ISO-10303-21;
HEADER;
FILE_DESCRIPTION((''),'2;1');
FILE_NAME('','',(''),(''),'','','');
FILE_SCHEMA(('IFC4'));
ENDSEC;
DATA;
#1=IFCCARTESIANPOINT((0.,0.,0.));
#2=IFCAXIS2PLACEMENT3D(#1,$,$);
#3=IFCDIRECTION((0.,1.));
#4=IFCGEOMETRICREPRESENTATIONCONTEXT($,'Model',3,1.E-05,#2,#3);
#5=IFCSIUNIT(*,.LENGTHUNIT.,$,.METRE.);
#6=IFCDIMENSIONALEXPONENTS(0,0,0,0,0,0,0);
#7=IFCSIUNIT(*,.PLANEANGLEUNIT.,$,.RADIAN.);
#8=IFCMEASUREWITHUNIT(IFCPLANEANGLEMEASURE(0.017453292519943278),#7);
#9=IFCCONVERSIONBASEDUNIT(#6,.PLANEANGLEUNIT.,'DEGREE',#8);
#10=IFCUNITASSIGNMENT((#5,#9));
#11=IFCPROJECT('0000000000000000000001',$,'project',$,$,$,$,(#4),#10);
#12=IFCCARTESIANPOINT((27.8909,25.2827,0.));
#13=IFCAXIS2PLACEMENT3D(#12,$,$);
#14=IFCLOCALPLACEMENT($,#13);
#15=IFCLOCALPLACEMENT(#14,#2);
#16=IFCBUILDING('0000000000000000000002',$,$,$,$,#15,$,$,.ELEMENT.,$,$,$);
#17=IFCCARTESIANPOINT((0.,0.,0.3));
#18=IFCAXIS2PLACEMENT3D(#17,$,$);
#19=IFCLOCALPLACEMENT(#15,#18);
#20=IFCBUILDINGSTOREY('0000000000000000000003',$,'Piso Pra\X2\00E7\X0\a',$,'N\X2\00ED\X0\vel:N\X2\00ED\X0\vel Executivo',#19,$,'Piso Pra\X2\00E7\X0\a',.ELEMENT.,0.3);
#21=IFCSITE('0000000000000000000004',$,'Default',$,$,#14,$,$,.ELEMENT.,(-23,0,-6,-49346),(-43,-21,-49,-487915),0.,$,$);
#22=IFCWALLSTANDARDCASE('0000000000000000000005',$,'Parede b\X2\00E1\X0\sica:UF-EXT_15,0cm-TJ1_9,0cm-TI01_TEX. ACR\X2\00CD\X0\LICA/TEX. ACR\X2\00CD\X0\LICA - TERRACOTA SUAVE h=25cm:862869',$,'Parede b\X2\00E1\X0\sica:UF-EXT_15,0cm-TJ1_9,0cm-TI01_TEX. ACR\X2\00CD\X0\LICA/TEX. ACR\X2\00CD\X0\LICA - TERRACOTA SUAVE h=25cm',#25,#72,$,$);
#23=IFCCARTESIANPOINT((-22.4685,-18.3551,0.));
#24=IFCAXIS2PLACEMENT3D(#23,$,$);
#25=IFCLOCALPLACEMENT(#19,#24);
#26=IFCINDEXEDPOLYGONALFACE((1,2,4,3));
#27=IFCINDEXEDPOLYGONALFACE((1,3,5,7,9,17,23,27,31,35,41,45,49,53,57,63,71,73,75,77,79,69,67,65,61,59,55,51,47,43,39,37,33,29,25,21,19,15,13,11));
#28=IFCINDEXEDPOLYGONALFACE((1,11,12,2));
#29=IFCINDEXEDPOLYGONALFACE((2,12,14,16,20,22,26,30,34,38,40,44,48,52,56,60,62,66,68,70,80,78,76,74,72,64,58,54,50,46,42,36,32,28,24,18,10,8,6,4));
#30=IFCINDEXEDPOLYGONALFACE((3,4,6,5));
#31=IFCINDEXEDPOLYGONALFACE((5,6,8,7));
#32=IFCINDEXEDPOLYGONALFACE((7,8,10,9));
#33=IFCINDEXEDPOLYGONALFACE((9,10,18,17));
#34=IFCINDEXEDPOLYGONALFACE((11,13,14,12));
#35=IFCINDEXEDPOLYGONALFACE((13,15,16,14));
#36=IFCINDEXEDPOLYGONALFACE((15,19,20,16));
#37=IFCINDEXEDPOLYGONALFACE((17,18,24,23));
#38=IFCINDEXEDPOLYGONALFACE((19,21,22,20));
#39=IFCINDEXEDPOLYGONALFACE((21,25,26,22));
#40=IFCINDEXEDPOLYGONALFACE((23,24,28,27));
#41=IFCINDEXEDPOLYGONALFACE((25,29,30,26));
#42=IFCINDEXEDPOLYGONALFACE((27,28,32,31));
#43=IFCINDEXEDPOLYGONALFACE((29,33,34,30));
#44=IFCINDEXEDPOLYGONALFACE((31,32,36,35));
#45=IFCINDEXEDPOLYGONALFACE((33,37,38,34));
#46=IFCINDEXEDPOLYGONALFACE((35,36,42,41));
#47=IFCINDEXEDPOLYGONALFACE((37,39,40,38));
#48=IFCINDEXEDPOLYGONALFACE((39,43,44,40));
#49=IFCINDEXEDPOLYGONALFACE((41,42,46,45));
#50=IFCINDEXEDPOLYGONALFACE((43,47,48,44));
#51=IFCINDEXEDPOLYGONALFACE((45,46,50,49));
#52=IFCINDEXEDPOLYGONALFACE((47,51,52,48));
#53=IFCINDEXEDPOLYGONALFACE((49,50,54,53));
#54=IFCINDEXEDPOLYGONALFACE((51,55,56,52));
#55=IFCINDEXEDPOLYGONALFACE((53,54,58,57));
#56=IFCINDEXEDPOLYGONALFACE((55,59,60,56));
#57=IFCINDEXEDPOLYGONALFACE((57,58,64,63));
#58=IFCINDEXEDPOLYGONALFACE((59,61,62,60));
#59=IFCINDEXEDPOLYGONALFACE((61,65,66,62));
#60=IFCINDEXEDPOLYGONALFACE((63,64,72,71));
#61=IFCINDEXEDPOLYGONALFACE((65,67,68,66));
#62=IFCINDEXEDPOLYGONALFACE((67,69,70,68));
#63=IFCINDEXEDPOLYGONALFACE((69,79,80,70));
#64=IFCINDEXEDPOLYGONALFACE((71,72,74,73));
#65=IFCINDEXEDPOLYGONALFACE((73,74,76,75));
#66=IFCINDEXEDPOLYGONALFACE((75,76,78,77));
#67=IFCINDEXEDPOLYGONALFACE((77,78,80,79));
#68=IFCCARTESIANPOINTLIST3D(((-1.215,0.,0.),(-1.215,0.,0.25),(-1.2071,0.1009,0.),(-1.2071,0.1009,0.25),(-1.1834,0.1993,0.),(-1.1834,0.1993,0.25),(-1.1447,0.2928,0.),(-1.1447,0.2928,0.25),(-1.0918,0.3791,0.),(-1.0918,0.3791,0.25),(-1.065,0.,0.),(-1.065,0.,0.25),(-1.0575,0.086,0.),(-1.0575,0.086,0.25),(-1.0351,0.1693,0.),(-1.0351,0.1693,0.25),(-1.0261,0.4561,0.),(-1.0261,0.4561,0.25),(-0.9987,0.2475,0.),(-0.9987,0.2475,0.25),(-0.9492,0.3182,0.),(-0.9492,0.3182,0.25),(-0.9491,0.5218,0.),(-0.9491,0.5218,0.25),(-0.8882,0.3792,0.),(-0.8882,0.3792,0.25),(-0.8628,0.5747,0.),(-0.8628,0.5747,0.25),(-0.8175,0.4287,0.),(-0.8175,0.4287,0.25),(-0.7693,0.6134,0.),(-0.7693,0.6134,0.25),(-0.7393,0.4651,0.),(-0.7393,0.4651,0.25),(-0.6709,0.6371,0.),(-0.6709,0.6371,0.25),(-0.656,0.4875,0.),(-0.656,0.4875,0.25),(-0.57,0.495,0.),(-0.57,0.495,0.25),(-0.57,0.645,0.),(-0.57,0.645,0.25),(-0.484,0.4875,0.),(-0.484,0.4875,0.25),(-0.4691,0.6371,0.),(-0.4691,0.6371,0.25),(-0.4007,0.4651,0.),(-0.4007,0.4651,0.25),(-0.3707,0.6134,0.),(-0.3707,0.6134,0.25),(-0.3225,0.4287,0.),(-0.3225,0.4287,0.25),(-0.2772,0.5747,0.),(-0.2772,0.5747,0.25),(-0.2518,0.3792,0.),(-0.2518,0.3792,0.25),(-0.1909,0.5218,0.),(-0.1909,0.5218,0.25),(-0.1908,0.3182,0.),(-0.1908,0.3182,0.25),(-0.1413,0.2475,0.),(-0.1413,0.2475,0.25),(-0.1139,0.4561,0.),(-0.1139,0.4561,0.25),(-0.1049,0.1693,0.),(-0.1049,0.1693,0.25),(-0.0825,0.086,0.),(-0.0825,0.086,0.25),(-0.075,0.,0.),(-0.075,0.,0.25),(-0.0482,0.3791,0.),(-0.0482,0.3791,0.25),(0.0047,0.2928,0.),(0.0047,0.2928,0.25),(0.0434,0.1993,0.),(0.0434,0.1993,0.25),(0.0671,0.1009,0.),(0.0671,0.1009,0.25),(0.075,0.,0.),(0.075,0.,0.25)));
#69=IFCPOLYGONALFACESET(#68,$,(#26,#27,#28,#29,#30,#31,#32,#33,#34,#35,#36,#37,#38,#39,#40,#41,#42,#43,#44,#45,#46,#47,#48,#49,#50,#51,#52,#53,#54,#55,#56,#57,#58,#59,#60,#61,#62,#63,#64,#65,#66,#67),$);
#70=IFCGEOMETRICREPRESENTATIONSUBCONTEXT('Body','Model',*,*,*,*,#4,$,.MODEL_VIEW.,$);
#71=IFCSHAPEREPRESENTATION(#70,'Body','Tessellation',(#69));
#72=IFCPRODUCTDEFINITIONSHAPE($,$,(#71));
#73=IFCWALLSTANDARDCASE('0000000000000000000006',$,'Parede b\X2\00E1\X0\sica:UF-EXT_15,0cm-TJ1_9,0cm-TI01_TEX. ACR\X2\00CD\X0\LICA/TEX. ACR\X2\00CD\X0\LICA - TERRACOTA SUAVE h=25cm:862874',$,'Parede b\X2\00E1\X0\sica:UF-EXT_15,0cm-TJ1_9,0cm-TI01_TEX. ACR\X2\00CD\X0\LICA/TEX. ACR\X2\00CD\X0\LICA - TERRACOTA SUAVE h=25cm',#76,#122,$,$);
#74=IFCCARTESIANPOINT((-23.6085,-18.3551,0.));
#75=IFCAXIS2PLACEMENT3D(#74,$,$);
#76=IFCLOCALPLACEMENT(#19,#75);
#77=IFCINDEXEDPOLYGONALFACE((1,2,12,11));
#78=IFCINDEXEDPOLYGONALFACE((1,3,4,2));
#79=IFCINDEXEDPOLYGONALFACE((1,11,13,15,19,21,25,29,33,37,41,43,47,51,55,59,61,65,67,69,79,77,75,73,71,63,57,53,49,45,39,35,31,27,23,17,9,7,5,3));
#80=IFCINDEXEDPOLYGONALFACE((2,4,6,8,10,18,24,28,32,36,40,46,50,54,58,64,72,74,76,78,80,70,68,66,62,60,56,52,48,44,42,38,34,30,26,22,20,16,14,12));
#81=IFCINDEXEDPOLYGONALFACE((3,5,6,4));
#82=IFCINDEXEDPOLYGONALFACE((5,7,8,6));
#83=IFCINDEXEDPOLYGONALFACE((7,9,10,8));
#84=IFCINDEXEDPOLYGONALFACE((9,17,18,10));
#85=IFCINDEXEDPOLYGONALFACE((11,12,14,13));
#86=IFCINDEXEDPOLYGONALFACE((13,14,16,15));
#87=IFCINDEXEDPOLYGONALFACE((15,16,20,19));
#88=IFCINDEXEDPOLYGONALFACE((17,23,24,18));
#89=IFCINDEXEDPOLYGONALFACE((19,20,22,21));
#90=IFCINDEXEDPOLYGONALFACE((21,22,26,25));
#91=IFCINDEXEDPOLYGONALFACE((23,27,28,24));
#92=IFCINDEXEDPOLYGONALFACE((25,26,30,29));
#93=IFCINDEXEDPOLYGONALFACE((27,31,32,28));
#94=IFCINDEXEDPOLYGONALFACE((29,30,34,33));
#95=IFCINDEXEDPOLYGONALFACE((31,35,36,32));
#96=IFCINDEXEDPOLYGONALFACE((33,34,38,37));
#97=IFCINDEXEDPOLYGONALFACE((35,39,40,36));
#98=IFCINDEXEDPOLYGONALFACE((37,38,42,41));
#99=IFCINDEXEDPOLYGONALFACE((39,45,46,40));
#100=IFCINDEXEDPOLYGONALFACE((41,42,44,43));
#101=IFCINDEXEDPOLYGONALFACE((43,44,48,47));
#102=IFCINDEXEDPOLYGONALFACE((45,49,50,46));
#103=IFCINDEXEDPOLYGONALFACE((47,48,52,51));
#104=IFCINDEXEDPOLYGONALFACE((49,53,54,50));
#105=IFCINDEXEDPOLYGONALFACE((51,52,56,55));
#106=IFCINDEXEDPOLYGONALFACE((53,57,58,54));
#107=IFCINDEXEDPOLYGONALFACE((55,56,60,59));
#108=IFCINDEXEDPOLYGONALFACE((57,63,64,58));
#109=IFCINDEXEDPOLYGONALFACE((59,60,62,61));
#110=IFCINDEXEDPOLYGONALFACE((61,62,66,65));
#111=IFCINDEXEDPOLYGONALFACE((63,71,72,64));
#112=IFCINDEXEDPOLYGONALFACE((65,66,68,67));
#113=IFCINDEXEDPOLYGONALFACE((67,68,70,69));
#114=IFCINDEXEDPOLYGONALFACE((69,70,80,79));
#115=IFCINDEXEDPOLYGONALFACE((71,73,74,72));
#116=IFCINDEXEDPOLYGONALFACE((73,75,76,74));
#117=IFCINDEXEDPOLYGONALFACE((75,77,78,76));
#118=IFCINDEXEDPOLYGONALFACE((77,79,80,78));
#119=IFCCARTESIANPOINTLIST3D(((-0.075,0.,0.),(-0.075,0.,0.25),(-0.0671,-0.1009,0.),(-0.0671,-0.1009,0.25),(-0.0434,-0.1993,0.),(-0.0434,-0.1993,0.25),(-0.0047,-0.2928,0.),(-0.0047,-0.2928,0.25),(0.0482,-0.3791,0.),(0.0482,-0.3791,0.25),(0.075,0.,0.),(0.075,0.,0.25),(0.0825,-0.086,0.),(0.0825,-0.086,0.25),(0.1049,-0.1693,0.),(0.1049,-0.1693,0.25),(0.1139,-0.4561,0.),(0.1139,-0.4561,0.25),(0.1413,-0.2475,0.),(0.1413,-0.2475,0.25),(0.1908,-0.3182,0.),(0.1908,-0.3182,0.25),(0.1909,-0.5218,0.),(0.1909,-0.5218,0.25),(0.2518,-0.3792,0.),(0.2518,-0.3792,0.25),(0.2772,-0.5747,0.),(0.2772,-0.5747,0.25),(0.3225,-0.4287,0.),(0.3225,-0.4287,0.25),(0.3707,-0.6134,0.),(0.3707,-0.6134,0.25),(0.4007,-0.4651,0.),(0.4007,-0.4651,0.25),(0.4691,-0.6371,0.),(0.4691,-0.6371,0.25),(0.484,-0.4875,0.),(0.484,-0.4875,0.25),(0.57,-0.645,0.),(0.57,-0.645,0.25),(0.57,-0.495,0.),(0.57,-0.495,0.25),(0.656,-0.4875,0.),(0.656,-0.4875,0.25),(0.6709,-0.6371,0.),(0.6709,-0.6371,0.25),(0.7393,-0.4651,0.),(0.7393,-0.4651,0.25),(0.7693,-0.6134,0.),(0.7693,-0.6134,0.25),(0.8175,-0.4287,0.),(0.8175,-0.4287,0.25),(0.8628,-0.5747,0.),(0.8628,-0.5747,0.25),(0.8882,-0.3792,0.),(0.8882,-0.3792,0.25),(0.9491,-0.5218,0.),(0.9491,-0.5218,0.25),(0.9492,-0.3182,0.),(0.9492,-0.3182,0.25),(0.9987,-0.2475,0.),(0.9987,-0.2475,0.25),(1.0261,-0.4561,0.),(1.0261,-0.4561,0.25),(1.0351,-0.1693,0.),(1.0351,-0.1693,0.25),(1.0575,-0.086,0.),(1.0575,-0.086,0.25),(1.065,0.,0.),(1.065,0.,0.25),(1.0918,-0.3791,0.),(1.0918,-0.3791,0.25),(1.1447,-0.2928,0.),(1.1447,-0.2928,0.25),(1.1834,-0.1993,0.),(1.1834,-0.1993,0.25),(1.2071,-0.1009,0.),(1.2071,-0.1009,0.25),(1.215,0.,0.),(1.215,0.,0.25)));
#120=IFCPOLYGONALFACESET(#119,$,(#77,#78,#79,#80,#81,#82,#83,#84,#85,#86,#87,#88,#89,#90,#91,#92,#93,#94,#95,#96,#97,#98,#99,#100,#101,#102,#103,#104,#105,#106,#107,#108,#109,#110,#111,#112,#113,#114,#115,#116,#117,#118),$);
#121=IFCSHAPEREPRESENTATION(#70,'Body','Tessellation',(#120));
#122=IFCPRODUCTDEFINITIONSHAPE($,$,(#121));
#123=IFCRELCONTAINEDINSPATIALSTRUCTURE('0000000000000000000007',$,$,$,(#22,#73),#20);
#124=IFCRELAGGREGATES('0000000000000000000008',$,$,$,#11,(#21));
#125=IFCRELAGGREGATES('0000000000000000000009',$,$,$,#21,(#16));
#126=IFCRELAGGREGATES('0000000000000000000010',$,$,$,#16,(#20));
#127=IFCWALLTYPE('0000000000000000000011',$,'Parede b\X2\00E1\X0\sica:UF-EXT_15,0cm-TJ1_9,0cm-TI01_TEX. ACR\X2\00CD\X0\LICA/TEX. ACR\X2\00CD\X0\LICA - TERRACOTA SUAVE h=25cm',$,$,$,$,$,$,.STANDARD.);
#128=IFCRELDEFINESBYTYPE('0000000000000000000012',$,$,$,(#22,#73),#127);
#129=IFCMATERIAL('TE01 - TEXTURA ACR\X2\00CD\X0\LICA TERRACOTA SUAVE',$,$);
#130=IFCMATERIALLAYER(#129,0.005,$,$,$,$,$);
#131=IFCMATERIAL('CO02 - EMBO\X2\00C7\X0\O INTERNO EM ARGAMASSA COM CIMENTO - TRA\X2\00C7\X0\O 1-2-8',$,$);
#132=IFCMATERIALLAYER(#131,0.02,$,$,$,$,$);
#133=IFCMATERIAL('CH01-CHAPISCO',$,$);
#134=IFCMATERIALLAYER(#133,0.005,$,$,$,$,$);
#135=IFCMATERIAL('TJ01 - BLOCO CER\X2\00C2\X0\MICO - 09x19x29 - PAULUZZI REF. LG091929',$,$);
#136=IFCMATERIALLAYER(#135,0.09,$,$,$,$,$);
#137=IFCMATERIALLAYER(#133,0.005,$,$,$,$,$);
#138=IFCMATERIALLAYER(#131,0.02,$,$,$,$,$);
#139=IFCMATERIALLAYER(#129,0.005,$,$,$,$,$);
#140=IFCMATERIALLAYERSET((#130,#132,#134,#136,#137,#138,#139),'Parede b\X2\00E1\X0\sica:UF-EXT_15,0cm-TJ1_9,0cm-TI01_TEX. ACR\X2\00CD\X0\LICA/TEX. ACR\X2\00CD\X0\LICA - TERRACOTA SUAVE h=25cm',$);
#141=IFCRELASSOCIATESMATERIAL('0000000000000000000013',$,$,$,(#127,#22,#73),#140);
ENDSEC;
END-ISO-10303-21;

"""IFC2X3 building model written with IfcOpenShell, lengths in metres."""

from ifc_helpers import new_model, entity, si_unit, converted_unit, direction, frame, frame_2d, origin, place, context, subcontext, project, spatial, polyline, circle_curve, parameter, trimmed, segment, composite_curve, outline, extrude, material, layer, layer_set, layer_usage, type_object, element, save


model = new_model("IFC2X3")

# Units and contexts
model_context = context("Model", 3, precision=1e-05, world=origin(), true_north=direction((0.0, 1.0)))
body_context = subcontext(model_context, "Body", "Model", "MODEL_VIEW")
ifc_project = project(units=[si_unit("LENGTHUNIT", "METRE"), converted_unit("PLANEANGLEUNIT", "DEGREE", entity("IfcPlaneAngleMeasure", 0.017453292519943278), si_unit("PLANEANGLEUNIT", "RADIAN"), dimensions=[0, 0, 0, 0, 0, 0, 0])], contexts=[model_context])

# Site, building, storey
site_placement = place(None, frame((27.8909, 25.2827, 0.0)))
site = spatial("IfcSite", under=ifc_project, at=site_placement, Name="Default", CompositionType="ELEMENT", RefLatitude=(-23, 0, -6, -49346), RefLongitude=(-43, -21, -49, -487915), RefElevation=0.0)
building_placement = place(site_placement, origin())
building = spatial("IfcBuilding", under=site, at=building_placement, CompositionType="ELEMENT")
storey_placement = place(building_placement, frame((0.0, 0.0, 0.3)))
storey = spatial("IfcBuildingStorey", under=building, at=storey_placement, Name="Piso Praça", ObjectType="Nível:Nível Executivo", LongName="Piso Praça", CompositionType="ELEMENT", Elevation=0.3)

# Walls
ifc_material_1 = material(Name="CO02 - EMBOÇO INTERNO EM ARGAMASSA COM CIMENTO - TRAÇO 1-2-8")
ifc_material_2 = material(Name="CH01-CHAPISCO")
ifc_material_3 = material(Name="TJ01 - BLOCO CERÂMICO - 09x19x29 - PAULUZZI REF. LG091929")
ifc_material_4 = material(Name="TE01 - TEXTURA ACRÍLICA TERRACOTA SUAVE")
ifc_layer_1 = layer(ifc_material_4, 0.005)
ifc_layer_2 = layer(ifc_material_1, 0.02)
ifc_layer_3 = layer(ifc_material_2, 0.005)
ifc_layer_4 = layer(ifc_material_3, 0.09)
ifc_layer_5 = layer(ifc_material_2, 0.005)
ifc_layer_6 = layer(ifc_material_1, 0.02)
ifc_layer_7 = layer(ifc_material_4, 0.005)
ifc_layer_set_1 = layer_set([ifc_layer_1, ifc_layer_2, ifc_layer_3, ifc_layer_4, ifc_layer_5, ifc_layer_6, ifc_layer_7], Name="Parede básica:UF-EXT_15,0cm-TJ1_9,0cm-TI01_TEX. ACRÍLICA/TEX. ACRÍLICA - TERRACOTA SUAVE h=25cm")
ifc_layer_usage_1 = layer_usage(ifc_layer_set_1, "AXIS2", "NEGATIVE", 0.075)
wall_type_1 = type_object("IfcWallType", Name="Parede básica:UF-EXT_15,0cm-TJ1_9,0cm-TI01_TEX. ACRÍLICA/TEX. ACRÍLICA - TERRACOTA SUAVE h=25cm", PredefinedType="STANDARD", material=ifc_layer_set_1)
wall_1_placement = place(storey_placement, frame((-22.4685, -18.3551, 0.0)))
element("IfcWallStandardCase", 1, at=wall_1_placement, inside=storey, type_object=wall_type_1, material=ifc_layer_usage_1, Name="Parede básica:UF-EXT_15,0cm-TJ1_9,0cm-TI01_TEX. ACRÍLICA/TEX. ACRÍLICA - TERRACOTA SUAVE h=25cm:862869", ObjectType="Parede básica:UF-EXT_15,0cm-TJ1_9,0cm-TI01_TEX. ACRÍLICA/TEX. ACRÍLICA - TERRACOTA SUAVE h=25cm", context=body_context, shape_type="SweptSolid", body=[
    extrude(outline(composite_curve([segment(trimmed(circle_curve(frame_2d((-0.57, 0.0), x_axis=(1.0, 0.0)), 0.495), [parameter(0.0)], [parameter(180.0)], True, "PARAMETER"), False, "CONTINUOUS"), segment(polyline([(-0.075, 0.0), (0.075, 0.0)]), True, "CONTINUOUS"), segment(trimmed(circle_curve(frame_2d((-0.57, 0.0), x_axis=(1.0, 0.0)), 0.645), [parameter(0.0)], [parameter(180.0)], True, "PARAMETER"), True, "CONTINUOUS"), segment(polyline([(-1.215, 0.0), (-1.065, 0.0)]), True, "CONTINUOUS")], self_intersect=False)), origin(), (0.0, 0.0, 1.0), 0.25),
])
wall_2_placement = place(storey_placement, frame((-23.6085, -18.3551, 0.0)))
element("IfcWallStandardCase", 2, at=wall_2_placement, inside=storey, type_object=wall_type_1, material=ifc_layer_usage_1, Name="Parede básica:UF-EXT_15,0cm-TJ1_9,0cm-TI01_TEX. ACRÍLICA/TEX. ACRÍLICA - TERRACOTA SUAVE h=25cm:862874", ObjectType="Parede básica:UF-EXT_15,0cm-TJ1_9,0cm-TI01_TEX. ACRÍLICA/TEX. ACRÍLICA - TERRACOTA SUAVE h=25cm", context=body_context, shape_type="SweptSolid", body=[
    extrude(outline(composite_curve([segment(trimmed(circle_curve(frame_2d((0.57, 0.0), x_axis=(1.0, 0.0)), 0.495), [parameter(180.0)], [parameter(0.0)], True, "PARAMETER"), False, "CONTINUOUS"), segment(polyline([(0.075, 0.0), (-0.075, 0.0)]), True, "CONTINUOUS"), segment(trimmed(circle_curve(frame_2d((0.57, 0.0), x_axis=(1.0, 0.0)), 0.645), [parameter(180.0)], [parameter(0.0)], True, "PARAMETER"), True, "CONTINUOUS"), segment(polyline([(1.215, 0.0), (1.065, 0.0)]), True, "CONTINUOUS")], self_intersect=False)), origin(), (0.0, 0.0, 1.0), 0.25),
])

save(model, "model.ifc")
